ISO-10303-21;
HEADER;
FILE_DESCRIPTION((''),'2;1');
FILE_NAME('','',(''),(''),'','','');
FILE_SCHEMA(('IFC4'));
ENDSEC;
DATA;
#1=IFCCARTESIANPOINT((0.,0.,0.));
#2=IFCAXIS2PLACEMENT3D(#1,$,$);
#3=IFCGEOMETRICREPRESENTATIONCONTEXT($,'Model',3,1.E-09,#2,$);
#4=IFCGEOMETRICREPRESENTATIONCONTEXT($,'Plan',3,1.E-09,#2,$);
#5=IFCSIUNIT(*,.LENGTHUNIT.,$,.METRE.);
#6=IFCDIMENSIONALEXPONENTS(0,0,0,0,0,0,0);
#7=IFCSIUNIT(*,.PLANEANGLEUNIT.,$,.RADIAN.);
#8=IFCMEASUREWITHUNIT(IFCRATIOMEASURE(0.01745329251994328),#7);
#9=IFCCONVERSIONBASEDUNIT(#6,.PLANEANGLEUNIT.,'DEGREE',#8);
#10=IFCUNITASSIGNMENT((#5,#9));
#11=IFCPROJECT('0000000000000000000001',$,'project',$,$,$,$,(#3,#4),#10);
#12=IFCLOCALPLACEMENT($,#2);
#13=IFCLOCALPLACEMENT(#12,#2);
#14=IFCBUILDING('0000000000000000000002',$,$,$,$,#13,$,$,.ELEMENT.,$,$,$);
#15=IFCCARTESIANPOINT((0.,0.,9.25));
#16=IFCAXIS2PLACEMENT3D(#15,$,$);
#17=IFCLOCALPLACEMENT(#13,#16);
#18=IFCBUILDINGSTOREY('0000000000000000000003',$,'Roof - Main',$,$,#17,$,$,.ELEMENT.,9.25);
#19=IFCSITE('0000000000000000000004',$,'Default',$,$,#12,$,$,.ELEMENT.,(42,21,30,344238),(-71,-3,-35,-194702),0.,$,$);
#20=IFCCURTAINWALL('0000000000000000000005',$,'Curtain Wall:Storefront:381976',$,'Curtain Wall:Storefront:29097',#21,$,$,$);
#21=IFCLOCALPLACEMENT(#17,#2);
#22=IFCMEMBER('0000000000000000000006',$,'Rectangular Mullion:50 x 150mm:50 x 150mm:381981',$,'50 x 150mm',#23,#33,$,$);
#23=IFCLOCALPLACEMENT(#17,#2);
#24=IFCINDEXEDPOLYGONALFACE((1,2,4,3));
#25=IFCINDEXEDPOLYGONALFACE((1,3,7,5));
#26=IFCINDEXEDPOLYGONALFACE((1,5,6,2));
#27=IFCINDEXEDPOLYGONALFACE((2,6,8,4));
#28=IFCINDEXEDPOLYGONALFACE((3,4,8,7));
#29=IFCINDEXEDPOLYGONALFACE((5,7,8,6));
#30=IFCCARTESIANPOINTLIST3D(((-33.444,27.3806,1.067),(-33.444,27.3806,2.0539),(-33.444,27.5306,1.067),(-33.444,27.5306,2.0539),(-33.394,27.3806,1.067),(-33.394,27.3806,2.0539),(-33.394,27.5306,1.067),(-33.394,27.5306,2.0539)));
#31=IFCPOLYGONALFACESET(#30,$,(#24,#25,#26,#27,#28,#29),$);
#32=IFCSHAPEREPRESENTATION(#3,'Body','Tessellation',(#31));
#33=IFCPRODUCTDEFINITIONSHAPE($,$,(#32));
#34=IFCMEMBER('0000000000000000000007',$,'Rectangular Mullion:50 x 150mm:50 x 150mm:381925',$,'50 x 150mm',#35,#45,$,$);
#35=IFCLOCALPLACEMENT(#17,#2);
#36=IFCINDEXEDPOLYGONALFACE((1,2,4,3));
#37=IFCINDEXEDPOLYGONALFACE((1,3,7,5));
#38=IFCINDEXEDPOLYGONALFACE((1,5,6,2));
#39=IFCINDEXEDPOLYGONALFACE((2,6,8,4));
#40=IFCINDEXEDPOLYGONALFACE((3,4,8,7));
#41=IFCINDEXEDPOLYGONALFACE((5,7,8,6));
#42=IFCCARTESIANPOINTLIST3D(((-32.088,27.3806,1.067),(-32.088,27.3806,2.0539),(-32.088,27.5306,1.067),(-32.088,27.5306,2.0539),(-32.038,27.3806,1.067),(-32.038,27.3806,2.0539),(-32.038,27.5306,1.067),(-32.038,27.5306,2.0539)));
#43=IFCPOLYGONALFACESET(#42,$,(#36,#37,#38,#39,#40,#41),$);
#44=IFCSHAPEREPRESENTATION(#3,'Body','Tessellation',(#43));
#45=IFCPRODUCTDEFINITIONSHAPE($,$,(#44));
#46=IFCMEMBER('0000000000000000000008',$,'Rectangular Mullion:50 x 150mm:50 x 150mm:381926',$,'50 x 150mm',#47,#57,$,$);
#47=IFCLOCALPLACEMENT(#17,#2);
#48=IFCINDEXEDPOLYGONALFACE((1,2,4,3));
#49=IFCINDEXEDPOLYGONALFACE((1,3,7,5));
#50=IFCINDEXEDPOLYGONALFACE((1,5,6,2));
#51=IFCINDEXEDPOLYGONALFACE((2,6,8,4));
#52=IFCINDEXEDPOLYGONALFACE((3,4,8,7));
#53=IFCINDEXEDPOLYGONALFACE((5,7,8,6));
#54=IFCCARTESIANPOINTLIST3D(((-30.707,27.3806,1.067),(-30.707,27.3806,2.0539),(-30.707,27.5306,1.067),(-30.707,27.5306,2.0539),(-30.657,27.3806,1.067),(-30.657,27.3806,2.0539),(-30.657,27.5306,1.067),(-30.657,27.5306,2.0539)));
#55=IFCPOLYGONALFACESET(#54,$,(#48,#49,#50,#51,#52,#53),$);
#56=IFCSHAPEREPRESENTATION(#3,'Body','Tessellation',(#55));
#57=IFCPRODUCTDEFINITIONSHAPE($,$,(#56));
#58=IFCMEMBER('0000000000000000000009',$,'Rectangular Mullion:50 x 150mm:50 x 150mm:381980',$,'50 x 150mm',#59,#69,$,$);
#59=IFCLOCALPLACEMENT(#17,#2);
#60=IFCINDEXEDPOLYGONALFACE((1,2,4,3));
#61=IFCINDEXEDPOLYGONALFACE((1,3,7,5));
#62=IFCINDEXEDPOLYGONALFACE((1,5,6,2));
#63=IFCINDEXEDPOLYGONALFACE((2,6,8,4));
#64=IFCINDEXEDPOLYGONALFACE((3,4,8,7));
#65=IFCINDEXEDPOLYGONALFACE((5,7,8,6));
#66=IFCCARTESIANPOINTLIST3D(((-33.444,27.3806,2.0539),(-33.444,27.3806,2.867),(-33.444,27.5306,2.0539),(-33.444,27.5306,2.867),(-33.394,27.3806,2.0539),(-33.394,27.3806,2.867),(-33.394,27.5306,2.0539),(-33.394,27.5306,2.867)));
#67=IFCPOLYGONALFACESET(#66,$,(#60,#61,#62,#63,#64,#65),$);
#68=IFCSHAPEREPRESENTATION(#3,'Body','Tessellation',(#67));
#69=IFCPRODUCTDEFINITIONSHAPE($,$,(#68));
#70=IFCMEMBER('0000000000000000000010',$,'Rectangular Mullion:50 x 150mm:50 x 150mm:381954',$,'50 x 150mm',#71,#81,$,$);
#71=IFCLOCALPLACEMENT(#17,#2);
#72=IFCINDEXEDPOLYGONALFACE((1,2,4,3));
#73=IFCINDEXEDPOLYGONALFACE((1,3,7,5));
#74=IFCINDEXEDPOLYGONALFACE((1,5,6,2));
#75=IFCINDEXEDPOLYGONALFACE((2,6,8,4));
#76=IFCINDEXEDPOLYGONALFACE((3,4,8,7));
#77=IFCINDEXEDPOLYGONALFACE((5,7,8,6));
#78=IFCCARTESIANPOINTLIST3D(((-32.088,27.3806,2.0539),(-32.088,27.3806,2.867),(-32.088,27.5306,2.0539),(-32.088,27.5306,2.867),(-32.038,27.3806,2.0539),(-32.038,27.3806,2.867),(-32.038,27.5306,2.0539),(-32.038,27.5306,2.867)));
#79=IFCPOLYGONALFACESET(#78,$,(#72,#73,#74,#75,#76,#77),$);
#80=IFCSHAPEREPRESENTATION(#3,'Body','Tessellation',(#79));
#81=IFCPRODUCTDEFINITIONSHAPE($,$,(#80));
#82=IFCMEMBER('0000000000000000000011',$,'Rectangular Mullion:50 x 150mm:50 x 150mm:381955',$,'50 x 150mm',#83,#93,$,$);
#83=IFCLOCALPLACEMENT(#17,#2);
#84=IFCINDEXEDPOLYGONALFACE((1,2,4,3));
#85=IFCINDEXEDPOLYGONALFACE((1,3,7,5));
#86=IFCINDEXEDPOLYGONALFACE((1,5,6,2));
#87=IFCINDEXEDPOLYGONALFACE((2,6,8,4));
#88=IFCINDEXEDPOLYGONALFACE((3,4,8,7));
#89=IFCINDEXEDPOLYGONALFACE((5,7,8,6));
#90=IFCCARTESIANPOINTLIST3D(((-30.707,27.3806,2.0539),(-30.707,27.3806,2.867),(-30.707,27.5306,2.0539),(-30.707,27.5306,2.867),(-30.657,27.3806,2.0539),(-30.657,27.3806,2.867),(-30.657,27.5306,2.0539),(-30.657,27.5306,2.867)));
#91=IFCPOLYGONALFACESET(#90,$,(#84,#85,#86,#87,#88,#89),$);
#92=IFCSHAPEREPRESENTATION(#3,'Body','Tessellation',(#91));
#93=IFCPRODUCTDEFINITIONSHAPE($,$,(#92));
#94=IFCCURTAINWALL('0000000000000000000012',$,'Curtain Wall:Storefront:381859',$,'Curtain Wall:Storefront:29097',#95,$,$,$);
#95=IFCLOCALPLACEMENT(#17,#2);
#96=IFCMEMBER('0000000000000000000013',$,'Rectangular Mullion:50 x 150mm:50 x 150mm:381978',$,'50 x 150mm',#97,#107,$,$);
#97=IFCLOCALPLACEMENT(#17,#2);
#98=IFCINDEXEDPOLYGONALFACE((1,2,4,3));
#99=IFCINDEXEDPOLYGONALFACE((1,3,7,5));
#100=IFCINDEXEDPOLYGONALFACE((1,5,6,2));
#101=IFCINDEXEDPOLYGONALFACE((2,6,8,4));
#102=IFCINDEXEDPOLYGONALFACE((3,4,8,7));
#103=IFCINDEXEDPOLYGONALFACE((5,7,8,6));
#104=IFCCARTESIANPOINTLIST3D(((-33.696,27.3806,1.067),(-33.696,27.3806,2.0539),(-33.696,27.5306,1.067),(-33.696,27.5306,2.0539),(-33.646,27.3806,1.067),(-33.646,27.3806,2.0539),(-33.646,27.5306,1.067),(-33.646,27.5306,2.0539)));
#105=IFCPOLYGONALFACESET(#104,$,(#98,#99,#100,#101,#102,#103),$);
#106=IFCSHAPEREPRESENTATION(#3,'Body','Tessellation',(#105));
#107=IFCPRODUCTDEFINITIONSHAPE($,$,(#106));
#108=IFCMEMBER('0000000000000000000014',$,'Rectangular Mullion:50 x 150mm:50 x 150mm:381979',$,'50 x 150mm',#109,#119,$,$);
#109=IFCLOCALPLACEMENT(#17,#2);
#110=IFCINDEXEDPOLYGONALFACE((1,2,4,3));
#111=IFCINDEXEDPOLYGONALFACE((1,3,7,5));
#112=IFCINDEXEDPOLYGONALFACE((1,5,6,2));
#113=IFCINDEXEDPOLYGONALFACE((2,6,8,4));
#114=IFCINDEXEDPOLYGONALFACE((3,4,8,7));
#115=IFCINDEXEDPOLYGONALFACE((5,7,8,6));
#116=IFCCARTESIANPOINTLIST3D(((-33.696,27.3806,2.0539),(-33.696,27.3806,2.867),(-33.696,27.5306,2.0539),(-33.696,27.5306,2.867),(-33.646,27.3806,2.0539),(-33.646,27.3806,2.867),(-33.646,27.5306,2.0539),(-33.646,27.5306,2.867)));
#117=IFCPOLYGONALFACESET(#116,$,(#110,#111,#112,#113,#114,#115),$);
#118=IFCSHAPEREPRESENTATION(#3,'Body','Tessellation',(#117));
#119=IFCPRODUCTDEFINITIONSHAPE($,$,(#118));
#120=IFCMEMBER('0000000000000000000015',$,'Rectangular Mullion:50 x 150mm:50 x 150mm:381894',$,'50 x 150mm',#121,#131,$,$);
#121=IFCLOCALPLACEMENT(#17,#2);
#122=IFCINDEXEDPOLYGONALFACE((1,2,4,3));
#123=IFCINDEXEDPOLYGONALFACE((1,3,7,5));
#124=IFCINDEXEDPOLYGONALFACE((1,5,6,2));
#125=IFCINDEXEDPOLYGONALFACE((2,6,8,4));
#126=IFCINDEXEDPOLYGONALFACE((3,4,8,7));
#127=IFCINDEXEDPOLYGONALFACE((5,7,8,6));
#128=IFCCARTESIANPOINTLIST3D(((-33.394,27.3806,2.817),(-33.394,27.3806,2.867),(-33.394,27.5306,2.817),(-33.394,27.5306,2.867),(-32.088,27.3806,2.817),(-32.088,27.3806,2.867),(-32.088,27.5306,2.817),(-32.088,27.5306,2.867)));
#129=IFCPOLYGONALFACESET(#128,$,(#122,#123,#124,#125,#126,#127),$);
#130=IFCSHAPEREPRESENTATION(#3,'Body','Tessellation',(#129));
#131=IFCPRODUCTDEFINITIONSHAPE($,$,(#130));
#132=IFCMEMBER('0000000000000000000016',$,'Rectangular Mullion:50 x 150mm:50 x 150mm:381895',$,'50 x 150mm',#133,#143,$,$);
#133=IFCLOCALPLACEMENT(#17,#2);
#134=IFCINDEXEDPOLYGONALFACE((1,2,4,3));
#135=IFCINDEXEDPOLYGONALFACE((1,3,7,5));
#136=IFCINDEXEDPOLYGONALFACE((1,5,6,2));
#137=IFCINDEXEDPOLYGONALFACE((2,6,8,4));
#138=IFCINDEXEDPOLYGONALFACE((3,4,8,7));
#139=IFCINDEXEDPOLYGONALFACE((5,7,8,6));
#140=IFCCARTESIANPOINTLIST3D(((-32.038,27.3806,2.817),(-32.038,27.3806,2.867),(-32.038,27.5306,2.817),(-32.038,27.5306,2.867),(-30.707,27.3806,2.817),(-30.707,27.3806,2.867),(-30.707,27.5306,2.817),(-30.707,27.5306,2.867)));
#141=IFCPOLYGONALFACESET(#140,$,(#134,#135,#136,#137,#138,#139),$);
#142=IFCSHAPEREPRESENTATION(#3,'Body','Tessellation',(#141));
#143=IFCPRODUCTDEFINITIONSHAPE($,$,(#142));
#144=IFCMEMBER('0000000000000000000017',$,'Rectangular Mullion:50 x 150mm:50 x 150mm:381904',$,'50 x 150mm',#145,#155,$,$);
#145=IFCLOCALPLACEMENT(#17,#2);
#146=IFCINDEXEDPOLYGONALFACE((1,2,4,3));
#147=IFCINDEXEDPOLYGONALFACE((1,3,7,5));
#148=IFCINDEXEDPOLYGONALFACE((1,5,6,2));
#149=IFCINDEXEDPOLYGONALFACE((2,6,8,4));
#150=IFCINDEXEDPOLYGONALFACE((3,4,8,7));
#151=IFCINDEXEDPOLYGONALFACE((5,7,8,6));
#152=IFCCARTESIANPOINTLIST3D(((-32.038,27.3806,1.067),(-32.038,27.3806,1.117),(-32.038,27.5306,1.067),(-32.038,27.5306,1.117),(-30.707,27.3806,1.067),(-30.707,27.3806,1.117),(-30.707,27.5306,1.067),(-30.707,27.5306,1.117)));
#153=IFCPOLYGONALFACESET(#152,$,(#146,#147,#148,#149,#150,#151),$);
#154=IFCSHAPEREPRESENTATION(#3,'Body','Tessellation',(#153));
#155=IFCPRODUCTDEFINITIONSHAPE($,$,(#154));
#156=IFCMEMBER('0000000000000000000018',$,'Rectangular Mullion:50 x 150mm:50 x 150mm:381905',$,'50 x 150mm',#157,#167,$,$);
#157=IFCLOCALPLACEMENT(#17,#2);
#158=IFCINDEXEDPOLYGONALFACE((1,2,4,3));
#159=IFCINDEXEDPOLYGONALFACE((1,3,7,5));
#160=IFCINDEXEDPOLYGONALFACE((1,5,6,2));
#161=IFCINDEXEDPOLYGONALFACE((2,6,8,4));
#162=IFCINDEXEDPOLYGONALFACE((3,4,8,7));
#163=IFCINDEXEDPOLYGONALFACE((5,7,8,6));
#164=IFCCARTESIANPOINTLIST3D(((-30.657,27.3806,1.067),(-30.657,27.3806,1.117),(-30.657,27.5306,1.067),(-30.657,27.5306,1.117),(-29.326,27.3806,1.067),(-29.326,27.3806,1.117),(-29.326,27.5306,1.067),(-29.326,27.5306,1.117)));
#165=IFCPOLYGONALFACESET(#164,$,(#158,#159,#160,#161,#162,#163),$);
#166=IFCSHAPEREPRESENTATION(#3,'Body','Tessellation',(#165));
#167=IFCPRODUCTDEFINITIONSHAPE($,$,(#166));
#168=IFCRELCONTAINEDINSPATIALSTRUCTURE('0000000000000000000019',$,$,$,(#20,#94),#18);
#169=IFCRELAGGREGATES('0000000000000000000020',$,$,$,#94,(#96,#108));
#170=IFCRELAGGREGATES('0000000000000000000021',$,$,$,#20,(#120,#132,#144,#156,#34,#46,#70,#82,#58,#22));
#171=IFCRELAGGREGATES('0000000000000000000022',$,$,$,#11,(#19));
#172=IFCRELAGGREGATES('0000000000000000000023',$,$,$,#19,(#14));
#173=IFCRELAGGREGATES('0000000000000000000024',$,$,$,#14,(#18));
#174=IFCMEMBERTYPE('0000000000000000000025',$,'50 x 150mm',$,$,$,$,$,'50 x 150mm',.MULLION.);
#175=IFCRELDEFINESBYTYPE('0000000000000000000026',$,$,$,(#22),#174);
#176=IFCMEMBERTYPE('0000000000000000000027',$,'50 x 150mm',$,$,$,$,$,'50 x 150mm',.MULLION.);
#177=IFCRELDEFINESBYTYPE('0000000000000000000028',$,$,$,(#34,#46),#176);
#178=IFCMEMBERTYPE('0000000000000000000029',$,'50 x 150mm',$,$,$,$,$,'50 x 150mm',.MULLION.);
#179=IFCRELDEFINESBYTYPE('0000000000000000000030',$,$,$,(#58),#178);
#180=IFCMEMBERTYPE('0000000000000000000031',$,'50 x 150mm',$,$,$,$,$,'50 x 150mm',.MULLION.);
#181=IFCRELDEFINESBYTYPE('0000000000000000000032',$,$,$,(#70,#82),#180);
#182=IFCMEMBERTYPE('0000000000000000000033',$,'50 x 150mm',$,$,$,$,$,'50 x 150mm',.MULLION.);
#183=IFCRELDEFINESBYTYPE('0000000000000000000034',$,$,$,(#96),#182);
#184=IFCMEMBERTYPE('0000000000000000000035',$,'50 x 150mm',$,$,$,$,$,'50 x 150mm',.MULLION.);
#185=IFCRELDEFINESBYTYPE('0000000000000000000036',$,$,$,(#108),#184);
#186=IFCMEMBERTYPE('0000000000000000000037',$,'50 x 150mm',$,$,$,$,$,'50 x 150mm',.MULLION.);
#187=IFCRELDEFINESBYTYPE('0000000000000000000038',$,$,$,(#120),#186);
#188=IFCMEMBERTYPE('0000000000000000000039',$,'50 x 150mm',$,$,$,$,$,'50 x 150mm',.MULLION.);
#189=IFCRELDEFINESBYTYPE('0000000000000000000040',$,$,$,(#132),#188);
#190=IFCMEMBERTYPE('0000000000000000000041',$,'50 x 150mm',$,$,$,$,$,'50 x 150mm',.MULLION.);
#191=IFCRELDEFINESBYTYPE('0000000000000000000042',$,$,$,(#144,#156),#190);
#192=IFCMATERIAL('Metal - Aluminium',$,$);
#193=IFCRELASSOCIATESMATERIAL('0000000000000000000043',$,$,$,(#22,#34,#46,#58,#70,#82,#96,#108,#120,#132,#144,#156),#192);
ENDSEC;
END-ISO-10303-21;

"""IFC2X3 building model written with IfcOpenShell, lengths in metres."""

from ifc_helpers import new_model, entity, si_unit, converted_unit, frame, origin, origin_2d_with_axis, place, context, project, spatial, rectangle, extrude, source, transform, mapped, material, type_object, type_shapes, element, aggregate, save


model = new_model("IFC2X3")

# Units and contexts
model_context = context("Model", 3, precision=1e-09, world=origin())
plan_context = context("Plan", 3, precision=1e-09, world=origin())
ifc_project = project(units=[si_unit("LENGTHUNIT", "METRE"), converted_unit("PLANEANGLEUNIT", "DEGREE", entity("IfcRatioMeasure", 0.01745329251994328), si_unit("PLANEANGLEUNIT", "RADIAN"), dimensions=[0, 0, 0, 0, 0, 0, 0])], contexts=[model_context, plan_context])

# Site, building, storey
site_placement = place(None, origin())
site = spatial("IfcSite", under=ifc_project, at=site_placement, Name="Default", CompositionType="ELEMENT", RefLatitude=(42, 21, 30, 344238), RefLongitude=(-71, -3, -35, -194702), RefElevation=0.0)
building_placement = place(site_placement, origin())
building = spatial("IfcBuilding", under=site, at=building_placement, CompositionType="ELEMENT")
storey_placement = place(building_placement, frame((0.0, 0.0, 9.25)))
storey = spatial("IfcBuildingStorey", under=building, at=storey_placement, Name="Roof - Main", CompositionType="ELEMENT", Elevation=9.25)

# Curtain walls, members
curtain_wall_1_placement = place(storey_placement, origin())
curtain_wall_1 = element("IfcCurtainWall", 1, at=curtain_wall_1_placement, inside=storey, Name="Curtain Wall:Storefront:381976", ObjectType="Curtain Wall:Storefront:29097")
ifc_material_1 = material(Name="Metal - Aluminium")
member_type_1 = type_object("IfcMemberType", Name="50 x 150mm", ElementType="50 x 150mm", PredefinedType="MULLION")
shared_shape_1 = source(origin(), model_context, "Body", "SweptSolid", [
    extrude(rectangle(XDim=0.05, YDim=0.15, at=origin_2d_with_axis()), frame((-0.025, 0.0, -0.9869), z_axis=(0.0, 0.0, 1.0), x_axis=(-1.0, 0.0, 0.0)), (0.0, 0.0, 1.0), 0.9869),
])
type_shapes(member_type_1, [shared_shape_1])
member_1_placement = place(storey_placement, frame((-33.444, 27.4556, 2.0539), z_axis=(0.0, 0.0, 1.0), x_axis=(-1.0, 0.0, 0.0)))
member_1 = element("IfcMember", 2, at=member_1_placement, type_object=member_type_1, material=ifc_material_1, Name="Rectangular Mullion:50 x 150mm:50 x 150mm:381981", ObjectType="50 x 150mm", context=model_context, shape_type="MappedRepresentation", body=[
    mapped(shared_shape_1, transform((0.0, 0.0, 0.0), scale=1.0)),
])
member_type_2 = type_object("IfcMemberType", Name="50 x 150mm", ElementType="50 x 150mm", PredefinedType="MULLION")
shared_shape_2 = source(origin(), model_context, "Body", "SweptSolid", [
    extrude(rectangle(XDim=0.05, YDim=0.15, at=origin_2d_with_axis()), frame((0.0, 0.0, -0.9869), z_axis=(0.0, 0.0, 1.0), x_axis=(-1.0, 0.0, 0.0)), (0.0, 0.0, 1.0), 0.9869),
])
type_shapes(member_type_2, [shared_shape_2])
member_2_placement = place(storey_placement, frame((-32.063, 27.4556, 1.067), z_axis=(0.0, 0.0, -1.0), x_axis=(1.0, 0.0, 0.0)))
member_2 = element("IfcMember", 3, at=member_2_placement, type_object=member_type_2, material=ifc_material_1, Name="Rectangular Mullion:50 x 150mm:50 x 150mm:381925", ObjectType="50 x 150mm", context=model_context, shape_type="MappedRepresentation", body=[
    mapped(shared_shape_2, transform((0.0, 0.0, 0.0), scale=1.0)),
])
member_3_placement = place(storey_placement, frame((-30.682, 27.4556, 1.067), z_axis=(0.0, 0.0, -1.0), x_axis=(1.0, 0.0, 0.0)))
member_3 = element("IfcMember", 4, at=member_3_placement, type_object=member_type_2, material=ifc_material_1, Name="Rectangular Mullion:50 x 150mm:50 x 150mm:381926", ObjectType="50 x 150mm", context=model_context, shape_type="MappedRepresentation", body=[
    mapped(shared_shape_2, transform((0.0, 0.0, 0.0), scale=1.0)),
])
member_type_3 = type_object("IfcMemberType", Name="50 x 150mm", ElementType="50 x 150mm", PredefinedType="MULLION")
shared_shape_3 = source(origin(), model_context, "Body", "SweptSolid", [
    extrude(rectangle(XDim=0.05, YDim=0.15, at=origin_2d_with_axis()), frame((-0.025, 0.0, -0.8131), z_axis=(0.0, 0.0, 1.0), x_axis=(-1.0, 0.0, 0.0)), (0.0, 0.0, 1.0), 0.8131),
])
type_shapes(member_type_3, [shared_shape_3])
member_4_placement = place(storey_placement, frame((-33.444, 27.4556, 2.867), z_axis=(0.0, 0.0, 1.0), x_axis=(-1.0, 0.0, 0.0)))
member_4 = element("IfcMember", 5, at=member_4_placement, type_object=member_type_3, material=ifc_material_1, Name="Rectangular Mullion:50 x 150mm:50 x 150mm:381980", ObjectType="50 x 150mm", context=model_context, shape_type="MappedRepresentation", body=[
    mapped(shared_shape_3, transform((0.0, 0.0, 0.0), scale=1.0)),
])
member_type_4 = type_object("IfcMemberType", Name="50 x 150mm", ElementType="50 x 150mm", PredefinedType="MULLION")
shared_shape_4 = source(origin(), model_context, "Body", "SweptSolid", [
    extrude(rectangle(XDim=0.05, YDim=0.15, at=origin_2d_with_axis()), frame((0.0, 0.0, -0.8131), z_axis=(0.0, 0.0, 1.0), x_axis=(-1.0, 0.0, 0.0)), (0.0, 0.0, 1.0), 0.8131),
])
type_shapes(member_type_4, [shared_shape_4])
member_5_placement = place(storey_placement, frame((-32.063, 27.4556, 2.0539), z_axis=(0.0, 0.0, -1.0), x_axis=(1.0, 0.0, 0.0)))
member_5 = element("IfcMember", 6, at=member_5_placement, type_object=member_type_4, material=ifc_material_1, Name="Rectangular Mullion:50 x 150mm:50 x 150mm:381954", ObjectType="50 x 150mm", context=model_context, shape_type="MappedRepresentation", body=[
    mapped(shared_shape_4, transform((0.0, 0.0, 0.0), scale=1.0)),
])
member_6_placement = place(storey_placement, frame((-30.682, 27.4556, 2.0539), z_axis=(0.0, 0.0, -1.0), x_axis=(1.0, 0.0, 0.0)))
member_6 = element("IfcMember", 7, at=member_6_placement, type_object=member_type_4, material=ifc_material_1, Name="Rectangular Mullion:50 x 150mm:50 x 150mm:381955", ObjectType="50 x 150mm", context=model_context, shape_type="MappedRepresentation", body=[
    mapped(shared_shape_4, transform((0.0, 0.0, 0.0), scale=1.0)),
])
curtain_wall_2_placement = place(storey_placement, origin())
curtain_wall_2 = element("IfcCurtainWall", 8, at=curtain_wall_2_placement, inside=storey, Name="Curtain Wall:Storefront:381859", ObjectType="Curtain Wall:Storefront:29097")
member_type_5 = type_object("IfcMemberType", Name="50 x 150mm", ElementType="50 x 150mm", PredefinedType="MULLION")
shared_shape_5 = source(origin(), model_context, "Body", "SweptSolid", [
    extrude(rectangle(XDim=0.05, YDim=0.15, at=origin_2d_with_axis()), frame((-0.025, 0.0, -0.9869), z_axis=(0.0, 0.0, 1.0), x_axis=(-1.0, 0.0, 0.0)), (0.0, 0.0, 1.0), 0.9869),
])
type_shapes(member_type_5, [shared_shape_5])
member_7_placement = place(storey_placement, frame((-33.646, 27.4556, 1.067), z_axis=(0.0, 0.0, -1.0), x_axis=(1.0, 0.0, 0.0)))
member_7 = element("IfcMember", 9, at=member_7_placement, type_object=member_type_5, material=ifc_material_1, Name="Rectangular Mullion:50 x 150mm:50 x 150mm:381978", ObjectType="50 x 150mm", context=model_context, shape_type="MappedRepresentation", body=[
    mapped(shared_shape_5, transform((0.0, 0.0, 0.0), scale=1.0)),
])
member_type_6 = type_object("IfcMemberType", Name="50 x 150mm", ElementType="50 x 150mm", PredefinedType="MULLION")
shared_shape_6 = source(origin(), model_context, "Body", "SweptSolid", [
    extrude(rectangle(XDim=0.05, YDim=0.15, at=origin_2d_with_axis()), frame((-0.025, 0.0, -0.8131), z_axis=(0.0, 0.0, 1.0), x_axis=(-1.0, 0.0, 0.0)), (0.0, 0.0, 1.0), 0.8131),
])
type_shapes(member_type_6, [shared_shape_6])
member_8_placement = place(storey_placement, frame((-33.646, 27.4556, 2.0539), z_axis=(0.0, 0.0, -1.0), x_axis=(1.0, 0.0, 0.0)))
member_8 = element("IfcMember", 10, at=member_8_placement, type_object=member_type_6, material=ifc_material_1, Name="Rectangular Mullion:50 x 150mm:50 x 150mm:381979", ObjectType="50 x 150mm", context=model_context, shape_type="MappedRepresentation", body=[
    mapped(shared_shape_6, transform((0.0, 0.0, 0.0), scale=1.0)),
])
aggregate(curtain_wall_2, [member_7, member_8])

# Members
member_type_7 = type_object("IfcMemberType", Name="50 x 150mm", ElementType="50 x 150mm", PredefinedType="MULLION")
shared_shape_7 = source(origin(), model_context, "Body", "SweptSolid", [
    extrude(rectangle(XDim=0.05, YDim=0.15, at=origin_2d_with_axis()), frame((-0.025, 0.0, -1.306), z_axis=(0.0, 0.0, 1.0), x_axis=(-1.0, 0.0, 0.0)), (0.0, 0.0, 1.0), 1.306),
])
type_shapes(member_type_7, [shared_shape_7])
member_9_placement = place(storey_placement, frame((-32.088, 27.4556, 2.867), z_axis=(1.0, 0.0, 0.0), x_axis=(0.0, 0.0, 1.0)))
member_9 = element("IfcMember", 11, at=member_9_placement, type_object=member_type_7, material=ifc_material_1, Name="Rectangular Mullion:50 x 150mm:50 x 150mm:381894", ObjectType="50 x 150mm", context=model_context, shape_type="MappedRepresentation", body=[
    mapped(shared_shape_7, transform((0.0, 0.0, 0.0), scale=1.0)),
])
member_type_8 = type_object("IfcMemberType", Name="50 x 150mm", ElementType="50 x 150mm", PredefinedType="MULLION")
shared_shape_8 = source(origin(), model_context, "Body", "SweptSolid", [
    extrude(rectangle(XDim=0.05, YDim=0.15, at=origin_2d_with_axis()), frame((-0.025, 0.0, -1.331), z_axis=(0.0, 0.0, 1.0), x_axis=(-1.0, 0.0, 0.0)), (0.0, 0.0, 1.0), 1.331),
])
type_shapes(member_type_8, [shared_shape_8])
member_10_placement = place(storey_placement, frame((-30.707, 27.4556, 2.867), z_axis=(1.0, 0.0, 0.0), x_axis=(0.0, 0.0, 1.0)))
member_10 = element("IfcMember", 12, at=member_10_placement, type_object=member_type_8, material=ifc_material_1, Name="Rectangular Mullion:50 x 150mm:50 x 150mm:381895", ObjectType="50 x 150mm", context=model_context, shape_type="MappedRepresentation", body=[
    mapped(shared_shape_8, transform((0.0, 0.0, 0.0), scale=1.0)),
])
member_type_9 = type_object("IfcMemberType", Name="50 x 150mm", ElementType="50 x 150mm", PredefinedType="MULLION")
shared_shape_9 = source(origin(), model_context, "Body", "SweptSolid", [
    extrude(rectangle(XDim=0.05, YDim=0.15, at=origin_2d_with_axis()), frame((-0.025, 0.0, -1.331), z_axis=(0.0, 0.0, 1.0), x_axis=(-1.0, 0.0, 0.0)), (0.0, 0.0, 1.0), 1.331),
])
type_shapes(member_type_9, [shared_shape_9])
member_11_placement = place(storey_placement, frame((-32.038, 27.4556, 1.067), z_axis=(-1.0, 0.0, 0.0), x_axis=(0.0, 0.0, -1.0)))
member_11 = element("IfcMember", 13, at=member_11_placement, type_object=member_type_9, material=ifc_material_1, Name="Rectangular Mullion:50 x 150mm:50 x 150mm:381904", ObjectType="50 x 150mm", context=model_context, shape_type="MappedRepresentation", body=[
    mapped(shared_shape_9, transform((0.0, 0.0, 0.0), scale=1.0)),
])
member_12_placement = place(storey_placement, frame((-30.657, 27.4556, 1.067), z_axis=(-1.0, 0.0, 0.0), x_axis=(0.0, 0.0, -1.0)))
member_12 = element("IfcMember", 14, at=member_12_placement, type_object=member_type_9, material=ifc_material_1, Name="Rectangular Mullion:50 x 150mm:50 x 150mm:381905", ObjectType="50 x 150mm", context=model_context, shape_type="MappedRepresentation", body=[
    mapped(shared_shape_9, transform((0.0, 0.0, 0.0), scale=1.0)),
])

aggregate(curtain_wall_1, [member_9, member_10, member_11, member_12, member_2, member_3, member_5, member_6, member_4, member_1])

save(model, "model.ifc")
